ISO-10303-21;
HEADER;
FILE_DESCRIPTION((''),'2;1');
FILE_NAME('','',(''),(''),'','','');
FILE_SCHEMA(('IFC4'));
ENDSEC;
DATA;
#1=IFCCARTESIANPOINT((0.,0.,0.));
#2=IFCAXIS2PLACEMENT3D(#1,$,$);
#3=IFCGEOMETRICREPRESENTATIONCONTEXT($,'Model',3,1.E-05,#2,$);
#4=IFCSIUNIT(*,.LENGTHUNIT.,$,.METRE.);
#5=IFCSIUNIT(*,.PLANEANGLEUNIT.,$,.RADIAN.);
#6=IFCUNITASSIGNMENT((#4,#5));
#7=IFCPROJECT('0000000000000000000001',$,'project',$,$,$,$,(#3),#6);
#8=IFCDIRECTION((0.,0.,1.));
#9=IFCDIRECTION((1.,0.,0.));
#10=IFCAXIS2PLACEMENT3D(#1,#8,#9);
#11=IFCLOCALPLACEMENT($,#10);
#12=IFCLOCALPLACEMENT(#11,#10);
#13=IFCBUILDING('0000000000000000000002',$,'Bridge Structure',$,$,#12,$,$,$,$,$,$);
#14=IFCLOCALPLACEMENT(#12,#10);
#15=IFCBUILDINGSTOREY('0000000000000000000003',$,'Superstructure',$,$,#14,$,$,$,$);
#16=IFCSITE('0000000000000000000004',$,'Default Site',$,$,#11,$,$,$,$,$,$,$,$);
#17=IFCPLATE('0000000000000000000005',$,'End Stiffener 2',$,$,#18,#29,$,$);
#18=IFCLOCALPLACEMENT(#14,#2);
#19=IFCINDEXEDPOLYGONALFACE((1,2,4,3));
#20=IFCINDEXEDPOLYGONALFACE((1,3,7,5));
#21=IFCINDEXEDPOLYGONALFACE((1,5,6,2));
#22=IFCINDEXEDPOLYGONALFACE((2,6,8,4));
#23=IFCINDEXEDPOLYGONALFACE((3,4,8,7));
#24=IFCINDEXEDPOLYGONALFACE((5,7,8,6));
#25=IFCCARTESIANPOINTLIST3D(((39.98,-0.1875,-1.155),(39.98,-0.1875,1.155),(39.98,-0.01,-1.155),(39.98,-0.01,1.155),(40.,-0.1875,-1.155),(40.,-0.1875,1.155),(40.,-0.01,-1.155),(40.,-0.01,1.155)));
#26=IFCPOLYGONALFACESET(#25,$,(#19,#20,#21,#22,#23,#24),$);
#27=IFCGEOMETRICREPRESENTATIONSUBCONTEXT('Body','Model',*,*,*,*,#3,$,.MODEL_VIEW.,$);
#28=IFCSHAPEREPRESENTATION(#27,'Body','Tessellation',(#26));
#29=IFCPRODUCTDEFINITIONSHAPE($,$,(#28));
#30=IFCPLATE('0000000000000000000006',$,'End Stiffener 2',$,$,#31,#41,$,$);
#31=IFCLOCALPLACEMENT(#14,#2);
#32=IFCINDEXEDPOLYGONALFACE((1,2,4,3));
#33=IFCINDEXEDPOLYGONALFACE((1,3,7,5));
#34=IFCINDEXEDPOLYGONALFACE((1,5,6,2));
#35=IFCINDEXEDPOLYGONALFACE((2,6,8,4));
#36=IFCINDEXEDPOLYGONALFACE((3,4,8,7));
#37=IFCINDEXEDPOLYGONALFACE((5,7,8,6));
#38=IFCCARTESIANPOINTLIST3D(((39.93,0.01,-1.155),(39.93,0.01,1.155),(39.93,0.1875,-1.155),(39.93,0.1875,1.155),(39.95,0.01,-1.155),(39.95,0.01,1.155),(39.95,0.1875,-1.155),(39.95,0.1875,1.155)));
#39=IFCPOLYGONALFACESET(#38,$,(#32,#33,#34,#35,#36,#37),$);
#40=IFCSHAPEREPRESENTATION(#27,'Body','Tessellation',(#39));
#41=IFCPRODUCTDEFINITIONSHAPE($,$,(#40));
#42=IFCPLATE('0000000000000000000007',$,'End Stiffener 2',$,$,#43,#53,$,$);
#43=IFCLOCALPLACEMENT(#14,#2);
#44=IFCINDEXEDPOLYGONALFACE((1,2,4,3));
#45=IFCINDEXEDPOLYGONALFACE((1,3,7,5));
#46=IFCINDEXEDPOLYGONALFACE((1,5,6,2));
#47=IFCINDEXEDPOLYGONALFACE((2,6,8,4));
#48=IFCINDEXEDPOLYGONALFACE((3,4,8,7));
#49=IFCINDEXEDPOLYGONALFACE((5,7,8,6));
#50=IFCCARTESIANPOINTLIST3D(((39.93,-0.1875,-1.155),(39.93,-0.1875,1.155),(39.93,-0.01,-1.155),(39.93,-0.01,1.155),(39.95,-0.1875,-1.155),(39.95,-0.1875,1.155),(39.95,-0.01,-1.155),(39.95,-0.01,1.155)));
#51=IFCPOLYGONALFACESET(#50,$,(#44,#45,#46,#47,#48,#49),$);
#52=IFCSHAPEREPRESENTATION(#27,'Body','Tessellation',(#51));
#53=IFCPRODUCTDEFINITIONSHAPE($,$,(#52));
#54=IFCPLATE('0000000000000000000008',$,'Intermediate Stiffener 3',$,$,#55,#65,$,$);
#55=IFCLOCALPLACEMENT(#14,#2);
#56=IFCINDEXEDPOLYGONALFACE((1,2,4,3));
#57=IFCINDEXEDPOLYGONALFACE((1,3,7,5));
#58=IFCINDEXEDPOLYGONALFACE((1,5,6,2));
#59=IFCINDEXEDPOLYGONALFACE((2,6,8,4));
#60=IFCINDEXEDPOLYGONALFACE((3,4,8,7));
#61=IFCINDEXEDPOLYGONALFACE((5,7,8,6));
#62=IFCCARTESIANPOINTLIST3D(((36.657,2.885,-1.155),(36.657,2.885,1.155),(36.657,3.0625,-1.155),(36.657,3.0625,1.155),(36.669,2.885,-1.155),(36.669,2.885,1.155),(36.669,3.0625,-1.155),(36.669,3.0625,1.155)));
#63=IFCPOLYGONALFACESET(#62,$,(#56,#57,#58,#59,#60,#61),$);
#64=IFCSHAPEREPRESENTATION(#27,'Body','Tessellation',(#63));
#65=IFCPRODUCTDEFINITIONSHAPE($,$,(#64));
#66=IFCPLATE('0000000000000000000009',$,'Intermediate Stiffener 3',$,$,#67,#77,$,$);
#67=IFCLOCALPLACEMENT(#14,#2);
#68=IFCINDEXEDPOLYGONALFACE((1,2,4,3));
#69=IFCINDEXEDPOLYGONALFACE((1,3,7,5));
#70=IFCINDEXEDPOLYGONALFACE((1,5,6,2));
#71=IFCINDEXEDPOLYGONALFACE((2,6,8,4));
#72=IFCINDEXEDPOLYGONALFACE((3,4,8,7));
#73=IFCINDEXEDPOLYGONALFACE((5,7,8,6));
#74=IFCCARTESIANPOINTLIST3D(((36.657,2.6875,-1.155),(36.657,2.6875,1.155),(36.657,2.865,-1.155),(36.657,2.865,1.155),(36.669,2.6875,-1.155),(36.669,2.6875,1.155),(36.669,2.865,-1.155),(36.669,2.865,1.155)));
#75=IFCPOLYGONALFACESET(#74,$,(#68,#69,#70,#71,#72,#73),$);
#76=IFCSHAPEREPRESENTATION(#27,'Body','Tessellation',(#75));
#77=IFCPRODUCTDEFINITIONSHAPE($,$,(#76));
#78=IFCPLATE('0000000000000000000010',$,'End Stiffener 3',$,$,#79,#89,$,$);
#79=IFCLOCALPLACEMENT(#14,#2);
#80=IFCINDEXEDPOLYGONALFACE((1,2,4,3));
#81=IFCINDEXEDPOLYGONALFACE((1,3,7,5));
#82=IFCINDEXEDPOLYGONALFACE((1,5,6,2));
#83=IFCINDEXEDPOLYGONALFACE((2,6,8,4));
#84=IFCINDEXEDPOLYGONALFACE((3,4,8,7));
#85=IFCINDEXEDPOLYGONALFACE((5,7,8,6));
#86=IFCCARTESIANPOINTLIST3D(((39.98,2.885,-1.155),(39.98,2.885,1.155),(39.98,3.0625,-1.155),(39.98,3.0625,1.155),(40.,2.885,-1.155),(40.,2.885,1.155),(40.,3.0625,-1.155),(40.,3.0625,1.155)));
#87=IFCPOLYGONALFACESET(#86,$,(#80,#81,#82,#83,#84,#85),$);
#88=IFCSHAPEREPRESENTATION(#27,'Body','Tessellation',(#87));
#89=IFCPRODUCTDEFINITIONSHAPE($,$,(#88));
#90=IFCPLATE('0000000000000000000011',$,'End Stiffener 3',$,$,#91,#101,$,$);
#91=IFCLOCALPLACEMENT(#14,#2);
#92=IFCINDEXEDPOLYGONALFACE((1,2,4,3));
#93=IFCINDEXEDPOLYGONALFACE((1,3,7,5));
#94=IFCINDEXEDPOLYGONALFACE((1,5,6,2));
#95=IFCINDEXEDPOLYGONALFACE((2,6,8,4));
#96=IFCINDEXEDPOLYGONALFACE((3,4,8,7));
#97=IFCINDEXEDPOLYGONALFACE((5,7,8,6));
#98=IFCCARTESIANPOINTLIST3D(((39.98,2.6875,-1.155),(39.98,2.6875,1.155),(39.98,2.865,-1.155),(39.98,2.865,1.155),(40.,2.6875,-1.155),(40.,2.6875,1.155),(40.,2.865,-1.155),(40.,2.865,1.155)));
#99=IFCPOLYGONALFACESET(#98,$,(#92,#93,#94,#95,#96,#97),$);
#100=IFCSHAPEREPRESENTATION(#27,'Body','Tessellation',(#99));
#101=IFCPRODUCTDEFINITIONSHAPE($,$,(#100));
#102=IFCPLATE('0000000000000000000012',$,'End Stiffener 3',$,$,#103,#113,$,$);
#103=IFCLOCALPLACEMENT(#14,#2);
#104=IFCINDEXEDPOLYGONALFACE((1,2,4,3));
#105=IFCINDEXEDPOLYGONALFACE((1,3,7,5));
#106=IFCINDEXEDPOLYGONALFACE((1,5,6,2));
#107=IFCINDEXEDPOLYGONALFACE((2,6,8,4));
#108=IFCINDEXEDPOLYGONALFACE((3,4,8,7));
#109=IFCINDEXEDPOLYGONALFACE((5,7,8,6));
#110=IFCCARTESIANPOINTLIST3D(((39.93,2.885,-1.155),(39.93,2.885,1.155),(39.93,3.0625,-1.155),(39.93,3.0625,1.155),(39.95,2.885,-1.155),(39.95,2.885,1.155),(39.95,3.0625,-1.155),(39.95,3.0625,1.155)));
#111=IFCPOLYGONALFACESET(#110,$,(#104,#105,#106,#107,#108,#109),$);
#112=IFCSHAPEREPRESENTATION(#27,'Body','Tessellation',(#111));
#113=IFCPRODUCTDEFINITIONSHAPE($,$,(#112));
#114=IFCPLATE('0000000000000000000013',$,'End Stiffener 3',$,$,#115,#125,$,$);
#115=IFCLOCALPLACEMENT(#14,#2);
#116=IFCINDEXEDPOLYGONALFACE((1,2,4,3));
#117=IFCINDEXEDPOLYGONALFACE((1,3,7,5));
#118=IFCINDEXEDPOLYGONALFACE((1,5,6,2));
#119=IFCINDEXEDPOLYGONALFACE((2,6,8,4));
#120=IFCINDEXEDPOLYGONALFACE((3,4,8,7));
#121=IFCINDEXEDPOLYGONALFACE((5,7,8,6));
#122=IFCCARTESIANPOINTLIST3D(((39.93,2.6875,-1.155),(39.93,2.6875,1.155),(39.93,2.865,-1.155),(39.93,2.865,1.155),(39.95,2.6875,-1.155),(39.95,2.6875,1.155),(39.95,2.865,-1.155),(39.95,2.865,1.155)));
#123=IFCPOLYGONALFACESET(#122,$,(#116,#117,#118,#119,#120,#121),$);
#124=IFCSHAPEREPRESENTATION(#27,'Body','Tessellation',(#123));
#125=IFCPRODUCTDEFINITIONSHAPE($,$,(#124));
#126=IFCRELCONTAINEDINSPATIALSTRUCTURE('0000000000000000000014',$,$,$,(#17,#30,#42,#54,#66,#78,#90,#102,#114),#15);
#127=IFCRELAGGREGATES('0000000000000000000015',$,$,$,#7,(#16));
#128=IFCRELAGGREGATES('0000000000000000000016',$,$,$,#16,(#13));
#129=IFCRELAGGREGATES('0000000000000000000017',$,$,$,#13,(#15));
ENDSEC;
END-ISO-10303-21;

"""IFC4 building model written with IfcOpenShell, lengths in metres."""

from ifc_helpers import new_model, si_unit, frame, origin, origin_with_axes, origin_2d_with_axis, place, context, subcontext, project, spatial, rectangle, extrude, element, save


model = new_model("IFC4")

# Units and contexts
model_context = context("Model", 3, precision=1e-05, world=origin())
body_context = subcontext(model_context, "Body", "Model", "MODEL_VIEW")
ifc_project = project(units=[si_unit("LENGTHUNIT", "METRE"), si_unit("PLANEANGLEUNIT", "RADIAN")], contexts=[model_context])

# Site, building, storey
site_placement = place(None, origin_with_axes())
site = spatial("IfcSite", under=ifc_project, at=site_placement, Name="Default Site")
building_placement = place(site_placement, origin_with_axes())
building = spatial("IfcBuilding", under=site, at=building_placement, Name="Bridge Structure")
storey_placement = place(building_placement, origin_with_axes())
storey = spatial("IfcBuildingStorey", under=building, at=storey_placement, Name="Superstructure")

# Plates
for number, where, z_axis, x_axis, name in (
    (1, (39.99, -0.0988, -1.155), (0.0, 0.0, 1.0), (1.0, 0.0, 0.0), "End Stiffener 2"),
    (2, (39.94, 0.0988, -1.155), (0.0, 0.0, 1.0), (1.0, 0.0, 0.0), "End Stiffener 2"),
    (3, (39.94, -0.0988, -1.155), (0.0, 0.0, 1.0), (1.0, 0.0, 0.0), "End Stiffener 2"),
):
    element("IfcPlate", number, at=place(storey_placement, frame(where, z_axis=z_axis, x_axis=x_axis)), inside=storey, Name=name, context=body_context, shape_type="SweptSolid", body=[
        extrude(rectangle(XDim=0.02, YDim=0.1775, at=origin_2d_with_axis()), origin_with_axes(), (0.0, 0.0, 1.0), 2.31),
    ])
for number, where, z_axis, x_axis, name in (
    (4, (36.663, 2.9737, -1.155), (0.0, 0.0, 1.0), (1.0, 0.0, 0.0), "Intermediate Stiffener 3"),
    (5, (36.663, 2.7763, -1.155), (0.0, 0.0, 1.0), (1.0, 0.0, 0.0), "Intermediate Stiffener 3"),
):
    element("IfcPlate", number, at=place(storey_placement, frame(where, z_axis=z_axis, x_axis=x_axis)), inside=storey, Name=name, context=body_context, shape_type="SweptSolid", body=[
        extrude(rectangle(XDim=0.012, YDim=0.1775, at=origin_2d_with_axis()), origin_with_axes(), (0.0, 0.0, 1.0), 2.31),
    ])
for number, where, z_axis, x_axis, name in (
    (6, (39.99, 2.9737, -1.155), (0.0, 0.0, 1.0), (1.0, 0.0, 0.0), "End Stiffener 3"),
    (7, (39.99, 2.7763, -1.155), (0.0, 0.0, 1.0), (1.0, 0.0, 0.0), "End Stiffener 3"),
    (8, (39.94, 2.9737, -1.155), (0.0, 0.0, 1.0), (1.0, 0.0, 0.0), "End Stiffener 3"),
    (9, (39.94, 2.7763, -1.155), (0.0, 0.0, 1.0), (1.0, 0.0, 0.0), "End Stiffener 3"),
):
    element("IfcPlate", number, at=place(storey_placement, frame(where, z_axis=z_axis, x_axis=x_axis)), inside=storey, Name=name, context=body_context, shape_type="SweptSolid", body=[
        extrude(rectangle(XDim=0.02, YDim=0.1775, at=origin_2d_with_axis()), origin_with_axes(), (0.0, 0.0, 1.0), 2.31),
    ])

save(model, "model.ifc")
